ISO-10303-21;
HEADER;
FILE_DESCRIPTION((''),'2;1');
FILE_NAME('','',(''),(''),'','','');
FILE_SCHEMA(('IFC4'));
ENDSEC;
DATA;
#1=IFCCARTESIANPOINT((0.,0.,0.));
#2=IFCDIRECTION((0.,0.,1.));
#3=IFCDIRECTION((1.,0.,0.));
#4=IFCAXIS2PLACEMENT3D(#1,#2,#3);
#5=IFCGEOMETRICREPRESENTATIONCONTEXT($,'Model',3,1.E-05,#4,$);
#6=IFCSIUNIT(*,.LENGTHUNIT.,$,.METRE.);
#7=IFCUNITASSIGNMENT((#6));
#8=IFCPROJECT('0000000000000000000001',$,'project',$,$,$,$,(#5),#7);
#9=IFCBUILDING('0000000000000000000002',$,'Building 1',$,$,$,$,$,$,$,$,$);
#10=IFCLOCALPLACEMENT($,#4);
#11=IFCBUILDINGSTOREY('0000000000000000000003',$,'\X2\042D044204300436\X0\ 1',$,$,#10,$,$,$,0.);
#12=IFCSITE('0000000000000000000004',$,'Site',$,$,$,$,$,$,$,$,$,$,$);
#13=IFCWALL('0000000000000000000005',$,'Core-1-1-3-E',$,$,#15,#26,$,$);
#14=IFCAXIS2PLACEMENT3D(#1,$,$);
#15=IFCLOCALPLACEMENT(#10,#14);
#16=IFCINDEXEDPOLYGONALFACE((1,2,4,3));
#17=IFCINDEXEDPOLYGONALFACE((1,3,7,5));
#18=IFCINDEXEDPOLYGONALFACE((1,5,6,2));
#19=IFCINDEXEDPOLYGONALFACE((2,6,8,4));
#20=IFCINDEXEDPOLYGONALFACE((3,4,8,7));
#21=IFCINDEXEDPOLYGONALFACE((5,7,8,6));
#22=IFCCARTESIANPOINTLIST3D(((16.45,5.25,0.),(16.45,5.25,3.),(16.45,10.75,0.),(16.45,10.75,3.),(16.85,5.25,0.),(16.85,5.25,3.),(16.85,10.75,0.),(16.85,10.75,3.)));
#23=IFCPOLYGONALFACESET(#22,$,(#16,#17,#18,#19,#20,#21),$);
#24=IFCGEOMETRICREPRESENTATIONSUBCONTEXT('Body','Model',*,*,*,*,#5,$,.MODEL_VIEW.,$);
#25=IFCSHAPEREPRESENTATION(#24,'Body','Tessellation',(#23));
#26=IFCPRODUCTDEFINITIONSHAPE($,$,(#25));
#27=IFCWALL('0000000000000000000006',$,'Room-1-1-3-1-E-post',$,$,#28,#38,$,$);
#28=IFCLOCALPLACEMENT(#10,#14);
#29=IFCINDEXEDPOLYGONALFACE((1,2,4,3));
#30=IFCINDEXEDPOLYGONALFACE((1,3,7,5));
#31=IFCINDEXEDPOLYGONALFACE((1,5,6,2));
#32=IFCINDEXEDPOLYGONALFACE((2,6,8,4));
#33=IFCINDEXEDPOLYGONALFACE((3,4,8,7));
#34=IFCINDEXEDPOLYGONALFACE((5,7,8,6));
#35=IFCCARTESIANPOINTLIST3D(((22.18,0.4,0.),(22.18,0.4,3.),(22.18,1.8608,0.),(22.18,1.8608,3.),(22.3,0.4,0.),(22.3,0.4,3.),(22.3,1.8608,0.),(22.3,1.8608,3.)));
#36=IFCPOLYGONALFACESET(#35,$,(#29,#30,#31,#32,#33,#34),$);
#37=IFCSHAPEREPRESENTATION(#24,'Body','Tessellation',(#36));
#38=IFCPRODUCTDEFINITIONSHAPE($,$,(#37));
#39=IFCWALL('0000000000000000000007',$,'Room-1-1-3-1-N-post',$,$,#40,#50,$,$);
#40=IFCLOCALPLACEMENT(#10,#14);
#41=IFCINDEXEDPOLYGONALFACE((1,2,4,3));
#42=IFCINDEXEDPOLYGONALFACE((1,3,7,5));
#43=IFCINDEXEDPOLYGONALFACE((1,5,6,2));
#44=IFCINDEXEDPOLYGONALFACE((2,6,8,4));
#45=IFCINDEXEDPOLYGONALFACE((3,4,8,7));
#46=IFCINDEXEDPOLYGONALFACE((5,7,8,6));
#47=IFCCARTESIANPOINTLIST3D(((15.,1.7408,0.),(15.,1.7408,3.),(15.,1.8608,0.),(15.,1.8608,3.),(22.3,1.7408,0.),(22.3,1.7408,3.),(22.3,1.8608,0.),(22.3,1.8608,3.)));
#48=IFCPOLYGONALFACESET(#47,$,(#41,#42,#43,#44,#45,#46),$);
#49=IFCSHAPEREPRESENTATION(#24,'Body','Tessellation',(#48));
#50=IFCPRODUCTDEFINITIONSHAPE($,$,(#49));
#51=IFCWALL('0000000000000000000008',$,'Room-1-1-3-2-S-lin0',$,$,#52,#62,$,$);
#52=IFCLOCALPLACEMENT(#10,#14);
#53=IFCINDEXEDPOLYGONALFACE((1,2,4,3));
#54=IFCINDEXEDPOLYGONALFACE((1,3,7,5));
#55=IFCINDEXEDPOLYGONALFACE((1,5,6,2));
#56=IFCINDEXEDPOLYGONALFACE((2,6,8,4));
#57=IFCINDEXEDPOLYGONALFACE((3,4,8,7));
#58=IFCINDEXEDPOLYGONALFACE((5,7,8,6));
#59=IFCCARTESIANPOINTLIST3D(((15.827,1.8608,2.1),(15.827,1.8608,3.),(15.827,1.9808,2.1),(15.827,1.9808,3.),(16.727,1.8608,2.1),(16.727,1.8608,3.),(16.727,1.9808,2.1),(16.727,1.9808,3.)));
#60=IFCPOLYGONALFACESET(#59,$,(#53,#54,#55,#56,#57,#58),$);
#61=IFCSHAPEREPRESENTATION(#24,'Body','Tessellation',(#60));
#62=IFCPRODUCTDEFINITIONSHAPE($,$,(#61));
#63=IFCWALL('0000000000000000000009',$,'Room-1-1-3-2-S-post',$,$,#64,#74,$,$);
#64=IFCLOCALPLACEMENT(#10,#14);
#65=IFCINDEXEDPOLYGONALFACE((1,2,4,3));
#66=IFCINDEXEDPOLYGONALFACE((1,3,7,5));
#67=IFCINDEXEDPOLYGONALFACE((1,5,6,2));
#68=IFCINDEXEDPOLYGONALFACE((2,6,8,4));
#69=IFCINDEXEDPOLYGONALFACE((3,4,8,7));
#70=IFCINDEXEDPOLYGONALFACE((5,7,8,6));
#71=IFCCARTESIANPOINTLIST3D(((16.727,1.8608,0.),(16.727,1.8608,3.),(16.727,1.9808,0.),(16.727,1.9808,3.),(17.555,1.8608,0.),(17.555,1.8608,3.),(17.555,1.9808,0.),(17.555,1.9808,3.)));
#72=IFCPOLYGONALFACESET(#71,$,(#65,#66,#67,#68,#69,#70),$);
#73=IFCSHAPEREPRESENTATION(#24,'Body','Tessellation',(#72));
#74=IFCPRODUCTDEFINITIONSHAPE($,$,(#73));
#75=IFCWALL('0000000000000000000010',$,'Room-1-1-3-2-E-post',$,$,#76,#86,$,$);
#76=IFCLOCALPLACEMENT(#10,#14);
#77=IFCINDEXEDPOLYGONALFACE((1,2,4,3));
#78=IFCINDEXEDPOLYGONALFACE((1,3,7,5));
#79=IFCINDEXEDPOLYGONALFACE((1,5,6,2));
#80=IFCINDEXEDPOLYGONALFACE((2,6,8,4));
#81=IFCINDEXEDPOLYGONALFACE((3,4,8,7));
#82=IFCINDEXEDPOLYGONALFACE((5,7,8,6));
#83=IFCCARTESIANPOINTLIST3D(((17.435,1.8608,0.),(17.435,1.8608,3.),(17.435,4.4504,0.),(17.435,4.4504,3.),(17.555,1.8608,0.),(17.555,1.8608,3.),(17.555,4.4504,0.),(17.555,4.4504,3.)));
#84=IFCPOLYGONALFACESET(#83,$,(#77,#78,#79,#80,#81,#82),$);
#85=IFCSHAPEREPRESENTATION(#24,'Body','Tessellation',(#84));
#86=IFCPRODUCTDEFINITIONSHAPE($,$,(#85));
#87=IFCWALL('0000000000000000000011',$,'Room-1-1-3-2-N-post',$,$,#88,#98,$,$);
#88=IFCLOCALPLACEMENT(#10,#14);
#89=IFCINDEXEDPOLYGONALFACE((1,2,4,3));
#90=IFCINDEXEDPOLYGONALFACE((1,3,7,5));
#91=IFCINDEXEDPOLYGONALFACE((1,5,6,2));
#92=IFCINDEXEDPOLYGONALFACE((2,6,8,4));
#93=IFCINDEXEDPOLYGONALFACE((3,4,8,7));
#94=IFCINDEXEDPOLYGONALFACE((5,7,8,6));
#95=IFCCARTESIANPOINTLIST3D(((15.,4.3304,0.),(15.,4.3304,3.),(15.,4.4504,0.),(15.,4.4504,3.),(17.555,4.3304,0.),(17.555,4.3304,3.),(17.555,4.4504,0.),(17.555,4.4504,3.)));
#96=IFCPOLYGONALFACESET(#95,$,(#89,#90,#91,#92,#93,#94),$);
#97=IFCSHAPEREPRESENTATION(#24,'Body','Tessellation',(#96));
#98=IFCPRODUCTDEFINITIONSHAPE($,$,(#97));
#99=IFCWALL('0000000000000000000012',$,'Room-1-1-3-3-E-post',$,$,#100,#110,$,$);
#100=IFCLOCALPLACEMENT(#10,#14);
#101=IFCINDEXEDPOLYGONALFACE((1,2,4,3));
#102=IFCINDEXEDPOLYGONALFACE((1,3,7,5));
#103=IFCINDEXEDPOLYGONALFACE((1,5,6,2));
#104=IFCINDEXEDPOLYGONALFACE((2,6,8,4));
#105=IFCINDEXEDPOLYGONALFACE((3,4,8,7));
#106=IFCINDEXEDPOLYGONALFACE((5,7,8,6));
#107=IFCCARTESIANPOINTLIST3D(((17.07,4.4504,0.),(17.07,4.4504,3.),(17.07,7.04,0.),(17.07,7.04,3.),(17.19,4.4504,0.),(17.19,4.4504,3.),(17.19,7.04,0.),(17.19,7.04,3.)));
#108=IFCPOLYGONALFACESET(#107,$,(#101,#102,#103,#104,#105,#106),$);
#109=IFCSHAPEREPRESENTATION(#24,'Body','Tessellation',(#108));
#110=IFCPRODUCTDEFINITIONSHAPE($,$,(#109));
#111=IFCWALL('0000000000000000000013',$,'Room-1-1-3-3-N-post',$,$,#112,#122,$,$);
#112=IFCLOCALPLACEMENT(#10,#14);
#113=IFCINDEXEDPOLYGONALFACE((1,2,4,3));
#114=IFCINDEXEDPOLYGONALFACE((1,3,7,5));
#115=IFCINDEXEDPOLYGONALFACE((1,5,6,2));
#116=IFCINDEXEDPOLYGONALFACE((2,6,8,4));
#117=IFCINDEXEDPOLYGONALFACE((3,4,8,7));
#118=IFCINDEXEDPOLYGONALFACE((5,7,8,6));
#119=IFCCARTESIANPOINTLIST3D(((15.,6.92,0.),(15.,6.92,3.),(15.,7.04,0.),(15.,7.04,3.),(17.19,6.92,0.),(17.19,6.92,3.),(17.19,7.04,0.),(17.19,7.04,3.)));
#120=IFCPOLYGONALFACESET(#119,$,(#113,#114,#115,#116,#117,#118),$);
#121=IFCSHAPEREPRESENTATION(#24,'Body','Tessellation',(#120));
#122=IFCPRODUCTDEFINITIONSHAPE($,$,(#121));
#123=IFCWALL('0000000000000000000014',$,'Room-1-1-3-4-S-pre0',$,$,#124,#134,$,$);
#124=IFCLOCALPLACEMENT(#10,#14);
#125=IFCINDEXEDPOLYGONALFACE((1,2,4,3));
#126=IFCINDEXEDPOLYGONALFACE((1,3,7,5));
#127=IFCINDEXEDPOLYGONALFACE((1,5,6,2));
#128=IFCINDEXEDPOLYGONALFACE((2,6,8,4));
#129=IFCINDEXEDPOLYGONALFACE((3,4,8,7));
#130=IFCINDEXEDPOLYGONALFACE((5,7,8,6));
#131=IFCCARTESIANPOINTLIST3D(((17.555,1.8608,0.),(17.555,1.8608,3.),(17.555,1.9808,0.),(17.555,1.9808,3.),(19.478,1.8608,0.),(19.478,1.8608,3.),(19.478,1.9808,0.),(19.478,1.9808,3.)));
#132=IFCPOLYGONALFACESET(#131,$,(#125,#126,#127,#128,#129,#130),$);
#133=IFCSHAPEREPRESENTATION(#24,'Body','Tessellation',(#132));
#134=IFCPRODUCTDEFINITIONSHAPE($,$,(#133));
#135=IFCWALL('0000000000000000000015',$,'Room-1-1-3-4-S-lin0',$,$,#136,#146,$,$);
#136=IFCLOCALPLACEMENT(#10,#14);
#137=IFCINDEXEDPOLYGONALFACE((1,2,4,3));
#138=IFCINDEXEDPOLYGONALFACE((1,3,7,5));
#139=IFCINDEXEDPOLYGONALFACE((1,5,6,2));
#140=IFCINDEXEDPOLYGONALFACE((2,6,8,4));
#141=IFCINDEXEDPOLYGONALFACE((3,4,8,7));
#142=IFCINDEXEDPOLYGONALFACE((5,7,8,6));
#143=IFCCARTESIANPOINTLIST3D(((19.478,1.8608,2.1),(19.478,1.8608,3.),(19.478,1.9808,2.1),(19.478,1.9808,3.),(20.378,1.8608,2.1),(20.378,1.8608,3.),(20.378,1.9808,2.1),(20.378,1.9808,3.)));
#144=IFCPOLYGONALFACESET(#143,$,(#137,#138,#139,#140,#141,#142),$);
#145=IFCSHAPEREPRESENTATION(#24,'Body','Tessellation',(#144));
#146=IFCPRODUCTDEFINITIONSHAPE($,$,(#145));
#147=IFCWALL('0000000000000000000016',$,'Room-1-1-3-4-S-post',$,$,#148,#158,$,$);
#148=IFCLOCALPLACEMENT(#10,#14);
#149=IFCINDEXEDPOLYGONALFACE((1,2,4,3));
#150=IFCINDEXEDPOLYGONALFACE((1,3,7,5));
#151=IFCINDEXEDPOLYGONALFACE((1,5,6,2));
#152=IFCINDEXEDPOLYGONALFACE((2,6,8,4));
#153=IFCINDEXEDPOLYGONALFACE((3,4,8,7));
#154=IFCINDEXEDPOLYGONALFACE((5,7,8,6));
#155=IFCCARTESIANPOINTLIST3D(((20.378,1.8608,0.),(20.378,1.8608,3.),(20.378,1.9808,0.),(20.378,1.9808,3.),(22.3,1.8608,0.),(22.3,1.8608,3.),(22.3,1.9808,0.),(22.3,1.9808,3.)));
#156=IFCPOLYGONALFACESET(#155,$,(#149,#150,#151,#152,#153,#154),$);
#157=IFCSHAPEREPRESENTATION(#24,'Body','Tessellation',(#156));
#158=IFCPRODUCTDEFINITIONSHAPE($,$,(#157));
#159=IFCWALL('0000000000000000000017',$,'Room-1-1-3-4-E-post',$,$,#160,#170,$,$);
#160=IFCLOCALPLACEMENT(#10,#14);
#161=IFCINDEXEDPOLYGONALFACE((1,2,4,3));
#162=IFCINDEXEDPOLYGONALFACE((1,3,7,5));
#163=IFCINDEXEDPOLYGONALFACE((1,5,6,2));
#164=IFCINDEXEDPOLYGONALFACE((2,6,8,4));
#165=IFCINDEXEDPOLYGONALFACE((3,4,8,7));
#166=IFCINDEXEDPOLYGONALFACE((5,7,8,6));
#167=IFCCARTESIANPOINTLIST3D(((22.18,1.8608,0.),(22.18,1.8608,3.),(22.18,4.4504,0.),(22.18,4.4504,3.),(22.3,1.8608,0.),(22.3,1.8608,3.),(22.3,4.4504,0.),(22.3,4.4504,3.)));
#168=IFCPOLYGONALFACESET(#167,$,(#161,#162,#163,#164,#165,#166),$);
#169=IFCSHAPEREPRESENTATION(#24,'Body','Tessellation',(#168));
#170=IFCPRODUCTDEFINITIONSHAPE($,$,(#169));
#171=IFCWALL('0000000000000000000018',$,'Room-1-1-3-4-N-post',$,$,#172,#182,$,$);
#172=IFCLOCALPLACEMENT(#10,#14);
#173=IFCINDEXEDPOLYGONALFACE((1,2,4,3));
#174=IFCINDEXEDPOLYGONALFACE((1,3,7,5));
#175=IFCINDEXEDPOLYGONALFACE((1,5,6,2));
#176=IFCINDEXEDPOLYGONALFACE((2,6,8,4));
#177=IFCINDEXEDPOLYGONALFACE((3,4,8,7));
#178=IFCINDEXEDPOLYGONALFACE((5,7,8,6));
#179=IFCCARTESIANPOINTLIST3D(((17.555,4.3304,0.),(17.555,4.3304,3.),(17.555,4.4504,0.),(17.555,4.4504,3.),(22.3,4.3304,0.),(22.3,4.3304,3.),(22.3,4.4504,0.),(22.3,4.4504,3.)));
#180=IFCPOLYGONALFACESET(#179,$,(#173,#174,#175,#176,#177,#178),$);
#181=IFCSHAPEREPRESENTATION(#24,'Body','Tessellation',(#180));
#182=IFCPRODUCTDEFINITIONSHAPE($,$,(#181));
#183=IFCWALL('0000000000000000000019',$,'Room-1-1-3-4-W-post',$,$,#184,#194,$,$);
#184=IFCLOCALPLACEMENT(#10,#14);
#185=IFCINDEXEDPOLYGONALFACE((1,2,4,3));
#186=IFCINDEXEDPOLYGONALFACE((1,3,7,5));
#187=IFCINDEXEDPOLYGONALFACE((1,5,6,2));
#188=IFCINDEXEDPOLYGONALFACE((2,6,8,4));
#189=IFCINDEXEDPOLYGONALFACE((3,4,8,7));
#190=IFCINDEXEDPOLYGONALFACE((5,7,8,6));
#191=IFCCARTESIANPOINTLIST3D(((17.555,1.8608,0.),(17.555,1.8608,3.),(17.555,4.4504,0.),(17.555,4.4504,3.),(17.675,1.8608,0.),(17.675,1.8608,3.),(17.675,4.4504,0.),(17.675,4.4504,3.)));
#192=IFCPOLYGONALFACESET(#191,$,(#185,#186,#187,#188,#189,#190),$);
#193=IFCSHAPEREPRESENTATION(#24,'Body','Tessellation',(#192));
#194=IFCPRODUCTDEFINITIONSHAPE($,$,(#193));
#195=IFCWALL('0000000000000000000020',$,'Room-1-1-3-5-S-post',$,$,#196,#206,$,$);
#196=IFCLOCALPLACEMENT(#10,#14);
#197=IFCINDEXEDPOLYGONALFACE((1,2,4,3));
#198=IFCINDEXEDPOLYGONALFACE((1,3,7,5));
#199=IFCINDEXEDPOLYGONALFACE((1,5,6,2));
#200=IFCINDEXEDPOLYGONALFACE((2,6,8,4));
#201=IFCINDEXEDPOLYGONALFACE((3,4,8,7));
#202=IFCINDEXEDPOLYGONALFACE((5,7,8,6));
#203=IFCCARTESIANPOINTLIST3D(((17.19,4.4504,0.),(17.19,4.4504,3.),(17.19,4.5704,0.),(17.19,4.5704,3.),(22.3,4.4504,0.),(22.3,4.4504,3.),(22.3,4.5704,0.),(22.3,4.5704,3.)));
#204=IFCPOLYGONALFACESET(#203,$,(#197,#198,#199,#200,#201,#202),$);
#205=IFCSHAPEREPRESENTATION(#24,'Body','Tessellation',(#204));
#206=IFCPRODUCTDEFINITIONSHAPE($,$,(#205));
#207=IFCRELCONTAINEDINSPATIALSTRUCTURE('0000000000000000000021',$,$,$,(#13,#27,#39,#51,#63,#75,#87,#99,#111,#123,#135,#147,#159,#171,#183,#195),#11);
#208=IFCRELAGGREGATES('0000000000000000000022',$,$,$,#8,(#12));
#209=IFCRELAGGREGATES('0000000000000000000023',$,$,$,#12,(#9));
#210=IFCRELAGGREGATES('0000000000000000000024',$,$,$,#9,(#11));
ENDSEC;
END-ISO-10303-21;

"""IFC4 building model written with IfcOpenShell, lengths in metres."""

from ifc_helpers import new_model, si_unit, frame, origin_with_axes, place, context, subcontext, project, spatial, indexed_curve, outline, extrude, element, save


model = new_model("IFC4")

# Units and contexts
model_context = context("Model", 3, precision=1e-05, world=origin_with_axes())
body_context = subcontext(model_context, "Body", "Model", "MODEL_VIEW")
ifc_project = project(units=[si_unit("LENGTHUNIT", "METRE")], contexts=[model_context])

# Site, building, storey
site = spatial("IfcSite", under=ifc_project, Name="Site")
building = spatial("IfcBuilding", under=site, Name="Building 1")
storey_placement = place(None, origin_with_axes())
storey = spatial("IfcBuildingStorey", under=building, at=storey_placement, Name="Этаж 1", Elevation=0.0)

# Walls
wall_1_placement = place(storey_placement, frame((16.85, 5.25, 0.0), z_axis=(0.0, 0.0, 1.0), x_axis=(0.0, 1.0, 0.0)))
element("IfcWall", 1, at=wall_1_placement, inside=storey, Name="Core-1-1-3-E", context=body_context, shape_type="SweptSolid", body=[
    extrude(outline(indexed_curve([(0.0, 0.0), (0.0, 0.4), (5.5, 0.4), (5.5, 0.0), (0.0, 0.0)], self_intersect=False)), origin_with_axes(), (0.0, 0.0, 1.0), 3.0),
])
wall_2_placement = place(storey_placement, frame((22.3, 0.4, 0.0), z_axis=(0.0, 0.0, 1.0), x_axis=(0.0, 1.0, 0.0)))
element("IfcWall", 2, at=wall_2_placement, inside=storey, Name="Room-1-1-3-1-E-post", context=body_context, shape_type="SweptSolid", body=[
    extrude(outline(indexed_curve([(0.0, 0.0), (0.0, 0.12), (1.4608, 0.12), (1.4608, 0.0), (0.0, 0.0)], self_intersect=False)), origin_with_axes(), (0.0, 0.0, 1.0), 3.0),
])
wall_3_placement = place(storey_placement, frame((22.3, 1.8608, 0.0), z_axis=(0.0, 0.0, 1.0), x_axis=(-1.0, 0.0, 0.0)))
element("IfcWall", 3, at=wall_3_placement, inside=storey, Name="Room-1-1-3-1-N-post", context=body_context, shape_type="SweptSolid", body=[
    extrude(outline(indexed_curve([(0.0, 0.0), (0.0, 0.12), (7.3, 0.12), (7.3, 0.0), (0.0, 0.0)], self_intersect=False)), origin_with_axes(), (0.0, 0.0, 1.0), 3.0),
])
wall_4_placement = place(storey_placement, frame((15.827, 1.8608, 2.1), z_axis=(0.0, 0.0, 1.0), x_axis=(1.0, 0.0, 0.0)))
element("IfcWall", 4, at=wall_4_placement, inside=storey, Name="Room-1-1-3-2-S-lin0", context=body_context, shape_type="SweptSolid", body=[
    extrude(outline(indexed_curve([(0.0, 0.0), (0.0, 0.12), (0.9, 0.12), (0.9, 0.0), (0.0, 0.0)], self_intersect=False)), origin_with_axes(), (0.0, 0.0, 1.0), 0.9),
])
wall_5_placement = place(storey_placement, frame((16.727, 1.8608, 0.0), z_axis=(0.0, 0.0, 1.0), x_axis=(1.0, 0.0, 0.0)))
element("IfcWall", 5, at=wall_5_placement, inside=storey, Name="Room-1-1-3-2-S-post", context=body_context, shape_type="SweptSolid", body=[
    extrude(outline(indexed_curve([(0.0, 0.0), (0.0, 0.12), (0.828, 0.12), (0.828, 0.0), (0.0, 0.0)], self_intersect=False)), origin_with_axes(), (0.0, 0.0, 1.0), 3.0),
])
wall_6_placement = place(storey_placement, frame((17.555, 1.8608, 0.0), z_axis=(0.0, 0.0, 1.0), x_axis=(0.0, 1.0, 0.0)))
element("IfcWall", 6, at=wall_6_placement, inside=storey, Name="Room-1-1-3-2-E-post", context=body_context, shape_type="SweptSolid", body=[
    extrude(outline(indexed_curve([(0.0, 0.0), (0.0, 0.12), (2.5896, 0.12), (2.5896, 0.0), (0.0, 0.0)], self_intersect=False)), origin_with_axes(), (0.0, 0.0, 1.0), 3.0),
])
wall_7_placement = place(storey_placement, frame((17.555, 4.4504, 0.0), z_axis=(0.0, 0.0, 1.0), x_axis=(-1.0, 0.0, 0.0)))
element("IfcWall", 7, at=wall_7_placement, inside=storey, Name="Room-1-1-3-2-N-post", context=body_context, shape_type="SweptSolid", body=[
    extrude(outline(indexed_curve([(0.0, 0.0), (0.0, 0.12), (2.555, 0.12), (2.555, 0.0), (0.0, 0.0)], self_intersect=False)), origin_with_axes(), (0.0, 0.0, 1.0), 3.0),
])
wall_8_placement = place(storey_placement, frame((17.19, 4.4504, 0.0), z_axis=(0.0, 0.0, 1.0), x_axis=(0.0, 1.0, 0.0)))
element("IfcWall", 8, at=wall_8_placement, inside=storey, Name="Room-1-1-3-3-E-post", context=body_context, shape_type="SweptSolid", body=[
    extrude(outline(indexed_curve([(0.0, 0.0), (0.0, 0.12), (2.5896, 0.12), (2.5896, 0.0), (0.0, 0.0)], self_intersect=False)), origin_with_axes(), (0.0, 0.0, 1.0), 3.0),
])
wall_9_placement = place(storey_placement, frame((17.19, 7.04, 0.0), z_axis=(0.0, 0.0, 1.0), x_axis=(-1.0, 0.0, 0.0)))
element("IfcWall", 9, at=wall_9_placement, inside=storey, Name="Room-1-1-3-3-N-post", context=body_context, shape_type="SweptSolid", body=[
    extrude(outline(indexed_curve([(0.0, 0.0), (0.0, 0.12), (2.19, 0.12), (2.19, 0.0), (0.0, 0.0)], self_intersect=False)), origin_with_axes(), (0.0, 0.0, 1.0), 3.0),
])
wall_10_placement = place(storey_placement, frame((17.555, 1.8608, 0.0), z_axis=(0.0, 0.0, 1.0), x_axis=(1.0, 0.0, 0.0)))
element("IfcWall", 10, at=wall_10_placement, inside=storey, Name="Room-1-1-3-4-S-pre0", context=body_context, shape_type="SweptSolid", body=[
    extrude(outline(indexed_curve([(0.0, 0.0), (0.0, 0.12), (1.923, 0.12), (1.923, 0.0), (0.0, 0.0)], self_intersect=False)), origin_with_axes(), (0.0, 0.0, 1.0), 3.0),
])
wall_11_placement = place(storey_placement, frame((19.478, 1.8608, 2.1), z_axis=(0.0, 0.0, 1.0), x_axis=(1.0, 0.0, 0.0)))
element("IfcWall", 11, at=wall_11_placement, inside=storey, Name="Room-1-1-3-4-S-lin0", context=body_context, shape_type="SweptSolid", body=[
    extrude(outline(indexed_curve([(0.0, 0.0), (0.0, 0.12), (0.9, 0.12), (0.9, 0.0), (0.0, 0.0)], self_intersect=False)), origin_with_axes(), (0.0, 0.0, 1.0), 0.9),
])
wall_12_placement = place(storey_placement, frame((20.378, 1.8608, 0.0), z_axis=(0.0, 0.0, 1.0), x_axis=(1.0, 0.0, 0.0)))
element("IfcWall", 12, at=wall_12_placement, inside=storey, Name="Room-1-1-3-4-S-post", context=body_context, shape_type="SweptSolid", body=[
    extrude(outline(indexed_curve([(0.0, 0.0), (0.0, 0.12), (1.922, 0.12), (1.922, 0.0), (0.0, 0.0)], self_intersect=False)), origin_with_axes(), (0.0, 0.0, 1.0), 3.0),
])
wall_13_placement = place(storey_placement, frame((22.3, 1.8608, 0.0), z_axis=(0.0, 0.0, 1.0), x_axis=(0.0, 1.0, 0.0)))
element("IfcWall", 13, at=wall_13_placement, inside=storey, Name="Room-1-1-3-4-E-post", context=body_context, shape_type="SweptSolid", body=[
    extrude(outline(indexed_curve([(0.0, 0.0), (0.0, 0.12), (2.5896, 0.12), (2.5896, 0.0), (0.0, 0.0)], self_intersect=False)), origin_with_axes(), (0.0, 0.0, 1.0), 3.0),
])
wall_14_placement = place(storey_placement, frame((22.3, 4.4504, 0.0), z_axis=(0.0, 0.0, 1.0), x_axis=(-1.0, 0.0, 0.0)))
element("IfcWall", 14, at=wall_14_placement, inside=storey, Name="Room-1-1-3-4-N-post", context=body_context, shape_type="SweptSolid", body=[
    extrude(outline(indexed_curve([(0.0, 0.0), (0.0, 0.12), (4.745, 0.12), (4.745, 0.0), (0.0, 0.0)], self_intersect=False)), origin_with_axes(), (0.0, 0.0, 1.0), 3.0),
])
wall_15_placement = place(storey_placement, frame((17.555, 4.4504, 0.0), z_axis=(0.0, 0.0, 1.0), x_axis=(0.0, -1.0, 0.0)))
element("IfcWall", 15, at=wall_15_placement, inside=storey, Name="Room-1-1-3-4-W-post", context=body_context, shape_type="SweptSolid", body=[
    extrude(outline(indexed_curve([(0.0, 0.0), (0.0, 0.12), (2.5896, 0.12), (2.5896, 0.0), (0.0, 0.0)], self_intersect=False)), origin_with_axes(), (0.0, 0.0, 1.0), 3.0),
])
wall_16_placement = place(storey_placement, frame((17.19, 4.4504, 0.0), z_axis=(0.0, 0.0, 1.0), x_axis=(1.0, 0.0, 0.0)))
element("IfcWall", 16, at=wall_16_placement, inside=storey, Name="Room-1-1-3-5-S-post", context=body_context, shape_type="SweptSolid", body=[
    extrude(outline(indexed_curve([(0.0, 0.0), (0.0, 0.12), (5.11, 0.12), (5.11, 0.0), (0.0, 0.0)], self_intersect=False)), origin_with_axes(), (0.0, 0.0, 1.0), 3.0),
])

save(model, "model.ifc")
